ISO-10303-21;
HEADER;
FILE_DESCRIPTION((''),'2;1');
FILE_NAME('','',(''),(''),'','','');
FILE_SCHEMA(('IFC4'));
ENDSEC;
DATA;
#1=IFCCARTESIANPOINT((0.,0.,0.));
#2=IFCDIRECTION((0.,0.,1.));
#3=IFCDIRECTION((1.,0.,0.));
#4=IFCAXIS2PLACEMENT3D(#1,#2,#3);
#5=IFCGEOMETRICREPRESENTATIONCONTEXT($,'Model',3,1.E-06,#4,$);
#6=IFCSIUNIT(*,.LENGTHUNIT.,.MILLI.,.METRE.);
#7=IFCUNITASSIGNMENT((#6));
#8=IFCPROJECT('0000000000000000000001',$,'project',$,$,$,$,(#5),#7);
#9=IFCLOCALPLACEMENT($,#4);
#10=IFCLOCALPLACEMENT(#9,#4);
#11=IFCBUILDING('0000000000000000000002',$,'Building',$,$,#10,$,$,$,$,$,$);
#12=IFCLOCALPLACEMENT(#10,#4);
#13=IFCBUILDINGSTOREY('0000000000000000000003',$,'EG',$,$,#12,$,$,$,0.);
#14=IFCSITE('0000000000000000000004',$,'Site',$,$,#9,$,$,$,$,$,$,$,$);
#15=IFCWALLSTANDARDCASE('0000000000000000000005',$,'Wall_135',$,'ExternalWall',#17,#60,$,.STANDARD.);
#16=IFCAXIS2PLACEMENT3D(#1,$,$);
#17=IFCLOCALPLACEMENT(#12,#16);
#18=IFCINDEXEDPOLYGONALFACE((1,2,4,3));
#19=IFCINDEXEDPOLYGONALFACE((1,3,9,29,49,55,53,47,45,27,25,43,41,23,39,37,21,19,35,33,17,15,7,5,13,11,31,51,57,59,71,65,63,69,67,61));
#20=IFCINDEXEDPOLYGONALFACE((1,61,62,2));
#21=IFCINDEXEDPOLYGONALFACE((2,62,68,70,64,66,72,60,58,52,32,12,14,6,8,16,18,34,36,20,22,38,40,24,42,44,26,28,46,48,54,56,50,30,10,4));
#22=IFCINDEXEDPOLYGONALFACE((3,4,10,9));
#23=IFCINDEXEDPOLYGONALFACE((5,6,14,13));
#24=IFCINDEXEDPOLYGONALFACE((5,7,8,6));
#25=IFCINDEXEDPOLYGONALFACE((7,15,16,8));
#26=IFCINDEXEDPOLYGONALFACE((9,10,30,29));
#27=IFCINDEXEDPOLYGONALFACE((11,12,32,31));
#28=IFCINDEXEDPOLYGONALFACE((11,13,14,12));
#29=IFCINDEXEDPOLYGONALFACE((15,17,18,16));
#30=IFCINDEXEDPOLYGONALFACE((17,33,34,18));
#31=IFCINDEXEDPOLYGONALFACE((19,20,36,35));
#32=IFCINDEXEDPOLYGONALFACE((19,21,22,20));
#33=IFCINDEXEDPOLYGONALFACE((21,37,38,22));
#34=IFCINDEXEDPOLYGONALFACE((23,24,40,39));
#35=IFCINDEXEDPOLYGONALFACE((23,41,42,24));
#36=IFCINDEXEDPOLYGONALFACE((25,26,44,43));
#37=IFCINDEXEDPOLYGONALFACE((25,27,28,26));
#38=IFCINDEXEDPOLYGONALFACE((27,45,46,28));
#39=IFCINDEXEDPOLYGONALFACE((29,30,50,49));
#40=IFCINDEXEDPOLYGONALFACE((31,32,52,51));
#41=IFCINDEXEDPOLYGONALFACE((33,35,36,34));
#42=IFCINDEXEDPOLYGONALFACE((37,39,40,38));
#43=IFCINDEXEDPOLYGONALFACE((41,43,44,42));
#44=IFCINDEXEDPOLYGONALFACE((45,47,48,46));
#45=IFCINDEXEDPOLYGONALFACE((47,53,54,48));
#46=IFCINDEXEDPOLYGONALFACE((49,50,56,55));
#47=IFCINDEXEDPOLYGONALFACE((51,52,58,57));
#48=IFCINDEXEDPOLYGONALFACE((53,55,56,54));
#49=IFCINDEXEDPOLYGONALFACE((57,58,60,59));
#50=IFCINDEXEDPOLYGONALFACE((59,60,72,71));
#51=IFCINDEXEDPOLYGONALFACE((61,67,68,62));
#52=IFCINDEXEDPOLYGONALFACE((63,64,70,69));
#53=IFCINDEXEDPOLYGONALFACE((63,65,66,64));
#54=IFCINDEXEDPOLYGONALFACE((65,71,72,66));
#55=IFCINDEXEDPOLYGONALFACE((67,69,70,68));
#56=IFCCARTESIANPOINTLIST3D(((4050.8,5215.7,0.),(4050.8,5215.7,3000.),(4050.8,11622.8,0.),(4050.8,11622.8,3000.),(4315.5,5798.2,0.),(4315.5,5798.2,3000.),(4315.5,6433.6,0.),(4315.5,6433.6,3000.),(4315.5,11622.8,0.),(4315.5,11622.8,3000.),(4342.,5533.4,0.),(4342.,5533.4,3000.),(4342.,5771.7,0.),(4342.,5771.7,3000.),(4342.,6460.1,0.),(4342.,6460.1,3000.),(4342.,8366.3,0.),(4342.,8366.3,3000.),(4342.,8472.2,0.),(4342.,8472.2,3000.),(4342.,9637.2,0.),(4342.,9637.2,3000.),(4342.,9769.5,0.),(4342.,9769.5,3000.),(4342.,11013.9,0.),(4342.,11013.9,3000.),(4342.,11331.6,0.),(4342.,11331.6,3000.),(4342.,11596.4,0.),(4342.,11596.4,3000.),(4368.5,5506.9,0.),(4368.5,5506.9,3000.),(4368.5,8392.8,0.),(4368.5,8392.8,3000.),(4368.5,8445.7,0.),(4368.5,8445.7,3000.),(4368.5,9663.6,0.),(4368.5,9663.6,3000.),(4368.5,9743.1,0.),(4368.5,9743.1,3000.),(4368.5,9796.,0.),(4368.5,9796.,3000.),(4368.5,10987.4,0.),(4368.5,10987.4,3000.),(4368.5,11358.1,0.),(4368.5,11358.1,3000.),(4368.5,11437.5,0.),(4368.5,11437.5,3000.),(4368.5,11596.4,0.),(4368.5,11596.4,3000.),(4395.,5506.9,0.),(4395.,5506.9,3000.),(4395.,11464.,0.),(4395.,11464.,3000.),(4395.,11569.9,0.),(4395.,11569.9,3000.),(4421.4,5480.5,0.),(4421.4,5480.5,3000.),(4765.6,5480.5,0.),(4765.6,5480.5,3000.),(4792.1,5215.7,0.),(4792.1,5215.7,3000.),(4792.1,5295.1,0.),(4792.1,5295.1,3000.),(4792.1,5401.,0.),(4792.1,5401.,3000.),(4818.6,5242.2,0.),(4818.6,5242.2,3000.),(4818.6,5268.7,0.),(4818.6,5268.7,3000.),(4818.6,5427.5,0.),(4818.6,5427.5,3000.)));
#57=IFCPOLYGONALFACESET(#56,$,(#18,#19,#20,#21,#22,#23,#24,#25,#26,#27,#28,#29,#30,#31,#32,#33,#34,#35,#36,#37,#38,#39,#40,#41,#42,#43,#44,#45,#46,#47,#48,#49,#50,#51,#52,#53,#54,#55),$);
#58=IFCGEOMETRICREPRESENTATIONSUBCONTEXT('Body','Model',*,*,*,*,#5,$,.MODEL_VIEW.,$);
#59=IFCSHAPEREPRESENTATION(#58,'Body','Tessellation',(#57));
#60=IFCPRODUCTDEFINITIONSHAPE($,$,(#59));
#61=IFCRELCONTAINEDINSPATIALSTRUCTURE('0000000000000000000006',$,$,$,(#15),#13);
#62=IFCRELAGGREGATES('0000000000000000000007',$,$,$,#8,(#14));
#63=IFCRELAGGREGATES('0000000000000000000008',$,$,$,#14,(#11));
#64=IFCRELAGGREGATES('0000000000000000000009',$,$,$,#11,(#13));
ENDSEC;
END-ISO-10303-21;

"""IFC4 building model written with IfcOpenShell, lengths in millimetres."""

from ifc_helpers import new_model, si_unit, frame, origin_with_axes, place, context, subcontext, project, spatial, polyline, outline, extrude, element, save


model = new_model("IFC4")

# Units and contexts
model_context = context("Model", 3, precision=1e-06, world=origin_with_axes())
body_context = subcontext(model_context, "Body", "Model", "MODEL_VIEW")
ifc_project = project(units=[si_unit("LENGTHUNIT", "METRE", prefix="MILLI")], contexts=[model_context])

# Site, building, storey
site_placement = place(None, origin_with_axes())
site = spatial("IfcSite", under=ifc_project, at=site_placement, Name="Site")
building_placement = place(site_placement, origin_with_axes())
building = spatial("IfcBuilding", under=site, at=building_placement, Name="Building")
storey_placement = place(building_placement, origin_with_axes())
storey = spatial("IfcBuildingStorey", under=building, at=storey_placement, Name="EG", Elevation=0.0)

# Wall
for number, where, z_axis, x_axis, name in (
    (1, (0.0, 0.0, 0.0), (0.0, 0.0, 1.0), (1.0, 0.0, 0.0), "Wall_135"),
):
    element("IfcWallStandardCase", number, at=place(storey_placement, frame(where, z_axis=z_axis, x_axis=x_axis)), inside=storey, Name=name, ObjectType="ExternalWall", PredefinedType="STANDARD", context=body_context, shape_type="SweptSolid", body=[
        extrude(outline(polyline([(4050.8, 5215.7, 0.0), (4050.8, 11622.8, 0.0), (4315.5, 11622.8, 0.0), (4342.0, 11596.4, 0.0), (4368.5, 11596.4, 0.0), (4395.0, 11569.9, 0.0), (4395.0, 11464.0, 0.0), (4368.5, 11437.5, 0.0), (4368.5, 11358.1, 0.0), (4342.0, 11331.6, 0.0), (4342.0, 11013.9, 0.0), (4368.5, 10987.4, 0.0), (4368.5, 9796.0, 0.0), (4342.0, 9769.5, 0.0), (4368.5, 9743.1, 0.0), (4368.5, 9663.6, 0.0), (4342.0, 9637.2, 0.0), (4342.0, 8472.2, 0.0), (4368.5, 8445.7, 0.0), (4368.5, 8392.8, 0.0), (4342.0, 8366.3, 0.0), (4342.0, 6460.1, 0.0), (4315.5, 6433.6, 0.0), (4315.5, 5798.2, 0.0), (4342.0, 5771.7, 0.0), (4342.0, 5533.4, 0.0), (4368.5, 5506.9, 0.0), (4395.0, 5506.9, 0.0), (4421.4, 5480.5, 0.0), (4765.6, 5480.5, 0.0), (4818.6, 5427.5, 0.0), (4792.1, 5401.0, 0.0), (4792.1, 5295.1, 0.0), (4818.6, 5268.7, 0.0), (4818.6, 5242.2, 0.0), (4792.1, 5215.7, 0.0), (4050.8, 5215.7, 0.0)])), origin_with_axes(), (0.0, 0.0, 1.0), 3000.0),
    ])

save(model, "model.ifc")
